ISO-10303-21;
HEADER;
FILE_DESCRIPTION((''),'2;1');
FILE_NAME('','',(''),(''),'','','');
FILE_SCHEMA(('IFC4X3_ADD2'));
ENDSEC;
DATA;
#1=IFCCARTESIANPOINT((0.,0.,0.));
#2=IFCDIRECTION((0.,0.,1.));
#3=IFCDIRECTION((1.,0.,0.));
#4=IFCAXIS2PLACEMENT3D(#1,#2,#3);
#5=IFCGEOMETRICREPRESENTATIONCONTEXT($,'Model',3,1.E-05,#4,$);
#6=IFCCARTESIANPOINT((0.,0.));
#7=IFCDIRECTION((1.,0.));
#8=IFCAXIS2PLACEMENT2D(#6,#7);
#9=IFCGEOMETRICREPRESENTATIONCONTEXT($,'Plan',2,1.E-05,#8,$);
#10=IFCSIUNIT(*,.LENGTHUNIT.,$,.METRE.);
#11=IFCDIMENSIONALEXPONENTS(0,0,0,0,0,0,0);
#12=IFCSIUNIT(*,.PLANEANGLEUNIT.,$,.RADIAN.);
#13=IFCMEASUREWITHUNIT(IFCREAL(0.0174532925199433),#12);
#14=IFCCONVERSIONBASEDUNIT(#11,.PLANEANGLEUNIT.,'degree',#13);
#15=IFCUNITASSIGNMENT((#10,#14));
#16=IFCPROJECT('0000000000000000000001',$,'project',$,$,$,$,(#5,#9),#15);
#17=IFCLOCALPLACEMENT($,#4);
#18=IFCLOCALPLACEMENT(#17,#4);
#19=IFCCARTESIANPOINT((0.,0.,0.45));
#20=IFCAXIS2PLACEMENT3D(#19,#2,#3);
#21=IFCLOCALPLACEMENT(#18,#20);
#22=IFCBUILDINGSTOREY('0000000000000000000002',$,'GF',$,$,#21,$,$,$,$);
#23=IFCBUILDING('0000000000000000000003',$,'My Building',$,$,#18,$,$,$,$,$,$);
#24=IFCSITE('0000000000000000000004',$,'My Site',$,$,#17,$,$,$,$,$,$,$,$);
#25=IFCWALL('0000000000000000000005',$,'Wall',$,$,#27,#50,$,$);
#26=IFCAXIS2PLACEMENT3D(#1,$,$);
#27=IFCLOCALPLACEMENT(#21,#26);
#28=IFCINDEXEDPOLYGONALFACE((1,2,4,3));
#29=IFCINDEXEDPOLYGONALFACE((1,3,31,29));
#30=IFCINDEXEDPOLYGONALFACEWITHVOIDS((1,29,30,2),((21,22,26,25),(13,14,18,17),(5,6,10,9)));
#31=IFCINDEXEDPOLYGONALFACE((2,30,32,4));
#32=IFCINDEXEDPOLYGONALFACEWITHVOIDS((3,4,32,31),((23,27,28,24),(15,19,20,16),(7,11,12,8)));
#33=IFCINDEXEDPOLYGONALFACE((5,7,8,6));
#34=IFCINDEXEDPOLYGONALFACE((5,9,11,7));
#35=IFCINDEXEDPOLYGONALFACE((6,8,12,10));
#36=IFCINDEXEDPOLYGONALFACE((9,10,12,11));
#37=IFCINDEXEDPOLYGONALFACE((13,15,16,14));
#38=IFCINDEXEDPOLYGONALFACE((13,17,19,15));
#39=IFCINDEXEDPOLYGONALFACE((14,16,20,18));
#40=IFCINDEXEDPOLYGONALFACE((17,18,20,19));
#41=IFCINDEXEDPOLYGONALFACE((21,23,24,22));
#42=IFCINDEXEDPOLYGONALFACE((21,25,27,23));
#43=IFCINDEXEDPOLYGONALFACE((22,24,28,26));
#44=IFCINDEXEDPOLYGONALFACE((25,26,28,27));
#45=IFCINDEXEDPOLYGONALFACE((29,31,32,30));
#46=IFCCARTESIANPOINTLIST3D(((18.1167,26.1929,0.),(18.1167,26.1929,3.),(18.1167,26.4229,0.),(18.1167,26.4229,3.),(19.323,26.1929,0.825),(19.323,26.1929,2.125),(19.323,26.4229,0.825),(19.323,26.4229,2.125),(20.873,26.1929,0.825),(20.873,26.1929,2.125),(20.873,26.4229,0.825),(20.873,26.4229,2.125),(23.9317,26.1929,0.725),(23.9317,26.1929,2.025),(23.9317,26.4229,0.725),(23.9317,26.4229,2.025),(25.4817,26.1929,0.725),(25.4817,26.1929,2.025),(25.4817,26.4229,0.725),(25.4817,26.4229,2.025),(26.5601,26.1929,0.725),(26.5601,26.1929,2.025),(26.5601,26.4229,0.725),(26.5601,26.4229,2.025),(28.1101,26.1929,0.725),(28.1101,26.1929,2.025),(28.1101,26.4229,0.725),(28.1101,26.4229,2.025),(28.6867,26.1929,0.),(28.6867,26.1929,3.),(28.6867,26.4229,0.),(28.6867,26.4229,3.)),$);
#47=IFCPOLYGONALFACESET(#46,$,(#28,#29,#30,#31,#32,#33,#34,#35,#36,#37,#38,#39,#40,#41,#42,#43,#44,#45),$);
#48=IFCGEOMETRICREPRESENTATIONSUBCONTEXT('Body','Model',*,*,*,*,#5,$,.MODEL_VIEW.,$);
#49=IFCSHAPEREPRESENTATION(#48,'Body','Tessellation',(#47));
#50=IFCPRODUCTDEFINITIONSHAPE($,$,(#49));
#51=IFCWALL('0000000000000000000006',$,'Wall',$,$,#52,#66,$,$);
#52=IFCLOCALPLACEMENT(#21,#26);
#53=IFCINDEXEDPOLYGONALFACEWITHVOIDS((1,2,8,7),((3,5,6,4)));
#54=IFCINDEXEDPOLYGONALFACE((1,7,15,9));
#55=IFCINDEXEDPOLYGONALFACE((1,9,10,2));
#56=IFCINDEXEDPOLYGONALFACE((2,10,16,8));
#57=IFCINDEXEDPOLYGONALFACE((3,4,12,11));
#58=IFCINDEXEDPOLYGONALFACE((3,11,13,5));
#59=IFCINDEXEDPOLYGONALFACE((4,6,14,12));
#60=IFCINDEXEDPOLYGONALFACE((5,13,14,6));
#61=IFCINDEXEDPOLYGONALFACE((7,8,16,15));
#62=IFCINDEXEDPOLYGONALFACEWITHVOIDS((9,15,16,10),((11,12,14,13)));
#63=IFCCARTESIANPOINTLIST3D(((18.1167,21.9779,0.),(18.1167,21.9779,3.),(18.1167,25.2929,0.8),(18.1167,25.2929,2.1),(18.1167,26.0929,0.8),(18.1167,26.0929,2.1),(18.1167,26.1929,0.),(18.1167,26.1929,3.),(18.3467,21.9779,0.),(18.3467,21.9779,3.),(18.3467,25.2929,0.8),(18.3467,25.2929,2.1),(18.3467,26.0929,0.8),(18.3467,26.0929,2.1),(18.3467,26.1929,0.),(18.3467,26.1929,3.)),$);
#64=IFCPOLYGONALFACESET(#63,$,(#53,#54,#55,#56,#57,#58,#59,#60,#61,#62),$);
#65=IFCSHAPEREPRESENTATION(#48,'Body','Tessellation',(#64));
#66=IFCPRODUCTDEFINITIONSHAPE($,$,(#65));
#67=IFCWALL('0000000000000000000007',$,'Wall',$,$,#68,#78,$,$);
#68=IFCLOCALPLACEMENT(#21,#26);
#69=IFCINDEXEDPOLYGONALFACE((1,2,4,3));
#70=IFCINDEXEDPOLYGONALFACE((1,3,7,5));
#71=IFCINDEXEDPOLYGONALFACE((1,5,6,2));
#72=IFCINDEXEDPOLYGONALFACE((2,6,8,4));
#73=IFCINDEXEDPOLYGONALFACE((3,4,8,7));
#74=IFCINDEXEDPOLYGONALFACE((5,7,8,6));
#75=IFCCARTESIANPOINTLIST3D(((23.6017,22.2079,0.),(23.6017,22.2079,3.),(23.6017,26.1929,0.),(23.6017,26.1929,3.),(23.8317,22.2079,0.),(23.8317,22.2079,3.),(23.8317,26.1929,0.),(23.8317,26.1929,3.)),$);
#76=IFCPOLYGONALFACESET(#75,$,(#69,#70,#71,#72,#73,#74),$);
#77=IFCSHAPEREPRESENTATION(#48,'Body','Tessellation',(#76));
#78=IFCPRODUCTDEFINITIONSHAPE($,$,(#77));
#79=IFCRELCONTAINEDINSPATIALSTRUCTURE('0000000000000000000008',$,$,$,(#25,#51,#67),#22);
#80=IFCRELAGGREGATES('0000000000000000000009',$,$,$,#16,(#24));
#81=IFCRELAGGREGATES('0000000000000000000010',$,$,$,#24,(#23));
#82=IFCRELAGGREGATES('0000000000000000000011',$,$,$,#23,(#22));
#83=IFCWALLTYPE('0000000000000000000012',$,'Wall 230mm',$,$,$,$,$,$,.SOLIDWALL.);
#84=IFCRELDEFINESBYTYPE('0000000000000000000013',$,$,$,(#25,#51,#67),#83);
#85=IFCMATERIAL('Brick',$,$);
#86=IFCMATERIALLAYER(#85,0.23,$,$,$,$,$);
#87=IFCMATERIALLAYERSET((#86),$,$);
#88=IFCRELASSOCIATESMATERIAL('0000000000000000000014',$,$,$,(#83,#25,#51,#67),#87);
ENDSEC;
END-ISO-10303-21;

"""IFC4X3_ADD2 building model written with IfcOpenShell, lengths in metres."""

from ifc_helpers import new_model, entity, si_unit, converted_unit, frame, origin_with_axes, origin_2d_with_axis, place, context, subcontext, project, spatial, line, indexed_curve, outline, extrude, source, transform, mapped, material, layer, layer_set, layer_usage, type_object, element, save


model = new_model("IFC4X3_ADD2")

# Units and contexts
model_context = context("Model", 3, precision=1e-05, world=origin_with_axes())
plan_context = context("Plan", 2, precision=1e-05, world=origin_2d_with_axis())
body_context_1 = subcontext(model_context, "Body", "Model", "MODEL_VIEW")
ifc_project = project(units=[si_unit("LENGTHUNIT", "METRE"), converted_unit("PLANEANGLEUNIT", "degree", entity("IfcReal", 0.0174532925199433), si_unit("PLANEANGLEUNIT", "RADIAN"), dimensions=[0, 0, 0, 0, 0, 0, 0])], contexts=[model_context, plan_context])

# Site, building, storey
site_placement = place(None, origin_with_axes())
site = spatial("IfcSite", under=ifc_project, at=site_placement, Name="My Site")
building_placement = place(site_placement, origin_with_axes())
building = spatial("IfcBuilding", under=site, at=building_placement, Name="My Building")
storey_placement = place(building_placement, frame((0.0, 0.0, 0.45), z_axis=(0.0, 0.0, 1.0), x_axis=(1.0, 0.0, 0.0)))
storey = spatial("IfcBuildingStorey", under=building, at=storey_placement, Name="GF")

# Wall, openings
ifc_material = material(Name="Brick")
ifc_layer_1 = layer(ifc_material, 0.23)
ifc_layer_set_1 = layer_set([ifc_layer_1])
ifc_layer_usage_1 = layer_usage(ifc_layer_set_1, "AXIS2", "POSITIVE", 0.0)
wall_type_1 = type_object("IfcWallType", Name="Wall 230mm", PredefinedType="SOLIDWALL", material=ifc_layer_set_1)
wall_1_placement = place(storey_placement, frame((18.1167, 26.1929, 0.0), z_axis=(0.0, 0.0, 1.0), x_axis=(1.0, 0.0, 0.0)))
wall_1 = element("IfcWall", 1, at=wall_1_placement, inside=storey, type_object=wall_type_1, material=ifc_layer_usage_1, Name="Wall", context=body_context_1, shape_type="SweptSolid", body=[
    extrude(outline(indexed_curve([(0.0, 0.0), (0.0, 0.23), (10.57, 0.23), (10.57, 0.0), (0.0, 0.0)], self_intersect=False)), origin_with_axes(), (0.0, 0.0, 1.0), 3.0),
])
shared_shape_1 = source(origin_with_axes(), body_context_1, "Body", "SweptSolid", [
    extrude(outline(indexed_curve([(0.0, 0.0), (1.55, 0.0), (1.55, 1.3), (0.0, 1.3)], segments=[line(1, 2, 3, 4, 1)])), frame((-0.775, -0.6, 0.0), z_axis=(0.0, -1.0, 0.0), x_axis=(1.0, 0.0, 0.0)), (0.0, 0.0, -1.0), 1.2),
])
opening_1_placement = place(wall_1_placement, frame((1.9813, 0.2, 0.825), z_axis=(0.0, 0.0, 1.0), x_axis=(-1.0, 0.0, 0.0)))
element("IfcOpeningElement", 2, at=opening_1_placement, cuts=wall_1, PredefinedType="OPENING", context=body_context_1, shape_type="MappedRepresentation", body=[
    mapped(shared_shape_1, transform((0.0, 0.0, 0.0), x_axis=(1.0, 0.0, 0.0), y_axis=(0.0, 1.0, 0.0), z_axis=(0.0, 0.0, 1.0), scale=1.0)),
])
opening_2_placement = place(wall_1_placement, frame((6.59, 0.07, 0.725), z_axis=(0.0, 0.0, 1.0), x_axis=(-1.0, 0.0, 0.0)))
element("IfcOpeningElement", 3, at=opening_2_placement, cuts=wall_1, PredefinedType="OPENING", context=body_context_1, shape_type="MappedRepresentation", body=[
    mapped(shared_shape_1, transform((0.0, 0.0, 0.0), x_axis=(1.0, 0.0, 0.0), y_axis=(0.0, 1.0, 0.0), z_axis=(0.0, 0.0, 1.0), scale=1.0)),
])
opening_3_placement = place(wall_1_placement, frame((9.2184, 0.0, 0.725), z_axis=(0.0, 0.0, 1.0), x_axis=(1.0, 0.0, 0.0)))
element("IfcOpeningElement", 4, at=opening_3_placement, cuts=wall_1, PredefinedType="OPENING", context=body_context_1, shape_type="MappedRepresentation", body=[
    mapped(shared_shape_1, transform((0.0, 0.0, 0.0), x_axis=(1.0, 0.0, 0.0), y_axis=(0.0, 1.0, 0.0), z_axis=(0.0, 0.0, 1.0), scale=1.0)),
])

# Wall, opening
ifc_layer_usage_2 = layer_usage(ifc_layer_set_1, "AXIS2", "POSITIVE", 0.0)
wall_2_placement = place(storey_placement, frame((18.3467, 21.9779, 0.0), z_axis=(0.0, 0.0, 1.0), x_axis=(0.0, 1.0, 0.0)))
wall_2 = element("IfcWall", 5, at=wall_2_placement, inside=storey, type_object=wall_type_1, material=ifc_layer_usage_2, Name="Wall", context=body_context_1, shape_type="SweptSolid", body=[
    extrude(outline(indexed_curve([(0.0, 0.0), (0.0, 0.23), (4.215, 0.23), (4.215, 0.0), (0.0, 0.0)], self_intersect=False)), origin_with_axes(), (0.0, 0.0, 1.0), 3.0),
])
shared_shape_2 = source(origin_with_axes(), body_context_1, "Body", "SweptSolid", [
    extrude(outline(indexed_curve([(0.0, 0.0), (0.8, 0.0), (0.8, 1.3), (0.0, 1.3)], segments=[line(1, 2, 3, 4, 1)])), frame((-0.4, -0.6, 0.0), z_axis=(0.0, -1.0, 0.0), x_axis=(1.0, 0.0, 0.0)), (0.0, 0.0, -1.0), 1.2),
])
opening_4_placement = place(wall_2_placement, frame((3.715, 0.0, 0.8), z_axis=(0.0, 0.0, 1.0), x_axis=(1.0, 0.0, 0.0)))
element("IfcOpeningElement", 6, at=opening_4_placement, cuts=wall_2, PredefinedType="OPENING", context=body_context_1, shape_type="MappedRepresentation", body=[
    mapped(shared_shape_2, transform((0.0, 0.0, 0.0), x_axis=(1.0, 0.0, 0.0), y_axis=(0.0, 1.0, 0.0), z_axis=(0.0, 0.0, 1.0), scale=1.0)),
])

# Wall
ifc_layer_usage_3 = layer_usage(ifc_layer_set_1, "AXIS2", "POSITIVE", 0.0)
wall_3_placement = place(storey_placement, frame((23.8317, 22.2079, 0.0), z_axis=(0.0, 0.0, 1.0), x_axis=(0.0, 1.0, 0.0)))
element("IfcWall", 7, at=wall_3_placement, inside=storey, type_object=wall_type_1, material=ifc_layer_usage_3, Name="Wall", context=body_context_1, shape_type="SweptSolid", body=[
    extrude(outline(indexed_curve([(0.0, 0.0), (0.0, 0.23), (3.985, 0.23), (3.985, 0.0), (0.0, 0.0)], self_intersect=False)), origin_with_axes(), (0.0, 0.0, 1.0), 3.0),
])

save(model, "model.ifc")
